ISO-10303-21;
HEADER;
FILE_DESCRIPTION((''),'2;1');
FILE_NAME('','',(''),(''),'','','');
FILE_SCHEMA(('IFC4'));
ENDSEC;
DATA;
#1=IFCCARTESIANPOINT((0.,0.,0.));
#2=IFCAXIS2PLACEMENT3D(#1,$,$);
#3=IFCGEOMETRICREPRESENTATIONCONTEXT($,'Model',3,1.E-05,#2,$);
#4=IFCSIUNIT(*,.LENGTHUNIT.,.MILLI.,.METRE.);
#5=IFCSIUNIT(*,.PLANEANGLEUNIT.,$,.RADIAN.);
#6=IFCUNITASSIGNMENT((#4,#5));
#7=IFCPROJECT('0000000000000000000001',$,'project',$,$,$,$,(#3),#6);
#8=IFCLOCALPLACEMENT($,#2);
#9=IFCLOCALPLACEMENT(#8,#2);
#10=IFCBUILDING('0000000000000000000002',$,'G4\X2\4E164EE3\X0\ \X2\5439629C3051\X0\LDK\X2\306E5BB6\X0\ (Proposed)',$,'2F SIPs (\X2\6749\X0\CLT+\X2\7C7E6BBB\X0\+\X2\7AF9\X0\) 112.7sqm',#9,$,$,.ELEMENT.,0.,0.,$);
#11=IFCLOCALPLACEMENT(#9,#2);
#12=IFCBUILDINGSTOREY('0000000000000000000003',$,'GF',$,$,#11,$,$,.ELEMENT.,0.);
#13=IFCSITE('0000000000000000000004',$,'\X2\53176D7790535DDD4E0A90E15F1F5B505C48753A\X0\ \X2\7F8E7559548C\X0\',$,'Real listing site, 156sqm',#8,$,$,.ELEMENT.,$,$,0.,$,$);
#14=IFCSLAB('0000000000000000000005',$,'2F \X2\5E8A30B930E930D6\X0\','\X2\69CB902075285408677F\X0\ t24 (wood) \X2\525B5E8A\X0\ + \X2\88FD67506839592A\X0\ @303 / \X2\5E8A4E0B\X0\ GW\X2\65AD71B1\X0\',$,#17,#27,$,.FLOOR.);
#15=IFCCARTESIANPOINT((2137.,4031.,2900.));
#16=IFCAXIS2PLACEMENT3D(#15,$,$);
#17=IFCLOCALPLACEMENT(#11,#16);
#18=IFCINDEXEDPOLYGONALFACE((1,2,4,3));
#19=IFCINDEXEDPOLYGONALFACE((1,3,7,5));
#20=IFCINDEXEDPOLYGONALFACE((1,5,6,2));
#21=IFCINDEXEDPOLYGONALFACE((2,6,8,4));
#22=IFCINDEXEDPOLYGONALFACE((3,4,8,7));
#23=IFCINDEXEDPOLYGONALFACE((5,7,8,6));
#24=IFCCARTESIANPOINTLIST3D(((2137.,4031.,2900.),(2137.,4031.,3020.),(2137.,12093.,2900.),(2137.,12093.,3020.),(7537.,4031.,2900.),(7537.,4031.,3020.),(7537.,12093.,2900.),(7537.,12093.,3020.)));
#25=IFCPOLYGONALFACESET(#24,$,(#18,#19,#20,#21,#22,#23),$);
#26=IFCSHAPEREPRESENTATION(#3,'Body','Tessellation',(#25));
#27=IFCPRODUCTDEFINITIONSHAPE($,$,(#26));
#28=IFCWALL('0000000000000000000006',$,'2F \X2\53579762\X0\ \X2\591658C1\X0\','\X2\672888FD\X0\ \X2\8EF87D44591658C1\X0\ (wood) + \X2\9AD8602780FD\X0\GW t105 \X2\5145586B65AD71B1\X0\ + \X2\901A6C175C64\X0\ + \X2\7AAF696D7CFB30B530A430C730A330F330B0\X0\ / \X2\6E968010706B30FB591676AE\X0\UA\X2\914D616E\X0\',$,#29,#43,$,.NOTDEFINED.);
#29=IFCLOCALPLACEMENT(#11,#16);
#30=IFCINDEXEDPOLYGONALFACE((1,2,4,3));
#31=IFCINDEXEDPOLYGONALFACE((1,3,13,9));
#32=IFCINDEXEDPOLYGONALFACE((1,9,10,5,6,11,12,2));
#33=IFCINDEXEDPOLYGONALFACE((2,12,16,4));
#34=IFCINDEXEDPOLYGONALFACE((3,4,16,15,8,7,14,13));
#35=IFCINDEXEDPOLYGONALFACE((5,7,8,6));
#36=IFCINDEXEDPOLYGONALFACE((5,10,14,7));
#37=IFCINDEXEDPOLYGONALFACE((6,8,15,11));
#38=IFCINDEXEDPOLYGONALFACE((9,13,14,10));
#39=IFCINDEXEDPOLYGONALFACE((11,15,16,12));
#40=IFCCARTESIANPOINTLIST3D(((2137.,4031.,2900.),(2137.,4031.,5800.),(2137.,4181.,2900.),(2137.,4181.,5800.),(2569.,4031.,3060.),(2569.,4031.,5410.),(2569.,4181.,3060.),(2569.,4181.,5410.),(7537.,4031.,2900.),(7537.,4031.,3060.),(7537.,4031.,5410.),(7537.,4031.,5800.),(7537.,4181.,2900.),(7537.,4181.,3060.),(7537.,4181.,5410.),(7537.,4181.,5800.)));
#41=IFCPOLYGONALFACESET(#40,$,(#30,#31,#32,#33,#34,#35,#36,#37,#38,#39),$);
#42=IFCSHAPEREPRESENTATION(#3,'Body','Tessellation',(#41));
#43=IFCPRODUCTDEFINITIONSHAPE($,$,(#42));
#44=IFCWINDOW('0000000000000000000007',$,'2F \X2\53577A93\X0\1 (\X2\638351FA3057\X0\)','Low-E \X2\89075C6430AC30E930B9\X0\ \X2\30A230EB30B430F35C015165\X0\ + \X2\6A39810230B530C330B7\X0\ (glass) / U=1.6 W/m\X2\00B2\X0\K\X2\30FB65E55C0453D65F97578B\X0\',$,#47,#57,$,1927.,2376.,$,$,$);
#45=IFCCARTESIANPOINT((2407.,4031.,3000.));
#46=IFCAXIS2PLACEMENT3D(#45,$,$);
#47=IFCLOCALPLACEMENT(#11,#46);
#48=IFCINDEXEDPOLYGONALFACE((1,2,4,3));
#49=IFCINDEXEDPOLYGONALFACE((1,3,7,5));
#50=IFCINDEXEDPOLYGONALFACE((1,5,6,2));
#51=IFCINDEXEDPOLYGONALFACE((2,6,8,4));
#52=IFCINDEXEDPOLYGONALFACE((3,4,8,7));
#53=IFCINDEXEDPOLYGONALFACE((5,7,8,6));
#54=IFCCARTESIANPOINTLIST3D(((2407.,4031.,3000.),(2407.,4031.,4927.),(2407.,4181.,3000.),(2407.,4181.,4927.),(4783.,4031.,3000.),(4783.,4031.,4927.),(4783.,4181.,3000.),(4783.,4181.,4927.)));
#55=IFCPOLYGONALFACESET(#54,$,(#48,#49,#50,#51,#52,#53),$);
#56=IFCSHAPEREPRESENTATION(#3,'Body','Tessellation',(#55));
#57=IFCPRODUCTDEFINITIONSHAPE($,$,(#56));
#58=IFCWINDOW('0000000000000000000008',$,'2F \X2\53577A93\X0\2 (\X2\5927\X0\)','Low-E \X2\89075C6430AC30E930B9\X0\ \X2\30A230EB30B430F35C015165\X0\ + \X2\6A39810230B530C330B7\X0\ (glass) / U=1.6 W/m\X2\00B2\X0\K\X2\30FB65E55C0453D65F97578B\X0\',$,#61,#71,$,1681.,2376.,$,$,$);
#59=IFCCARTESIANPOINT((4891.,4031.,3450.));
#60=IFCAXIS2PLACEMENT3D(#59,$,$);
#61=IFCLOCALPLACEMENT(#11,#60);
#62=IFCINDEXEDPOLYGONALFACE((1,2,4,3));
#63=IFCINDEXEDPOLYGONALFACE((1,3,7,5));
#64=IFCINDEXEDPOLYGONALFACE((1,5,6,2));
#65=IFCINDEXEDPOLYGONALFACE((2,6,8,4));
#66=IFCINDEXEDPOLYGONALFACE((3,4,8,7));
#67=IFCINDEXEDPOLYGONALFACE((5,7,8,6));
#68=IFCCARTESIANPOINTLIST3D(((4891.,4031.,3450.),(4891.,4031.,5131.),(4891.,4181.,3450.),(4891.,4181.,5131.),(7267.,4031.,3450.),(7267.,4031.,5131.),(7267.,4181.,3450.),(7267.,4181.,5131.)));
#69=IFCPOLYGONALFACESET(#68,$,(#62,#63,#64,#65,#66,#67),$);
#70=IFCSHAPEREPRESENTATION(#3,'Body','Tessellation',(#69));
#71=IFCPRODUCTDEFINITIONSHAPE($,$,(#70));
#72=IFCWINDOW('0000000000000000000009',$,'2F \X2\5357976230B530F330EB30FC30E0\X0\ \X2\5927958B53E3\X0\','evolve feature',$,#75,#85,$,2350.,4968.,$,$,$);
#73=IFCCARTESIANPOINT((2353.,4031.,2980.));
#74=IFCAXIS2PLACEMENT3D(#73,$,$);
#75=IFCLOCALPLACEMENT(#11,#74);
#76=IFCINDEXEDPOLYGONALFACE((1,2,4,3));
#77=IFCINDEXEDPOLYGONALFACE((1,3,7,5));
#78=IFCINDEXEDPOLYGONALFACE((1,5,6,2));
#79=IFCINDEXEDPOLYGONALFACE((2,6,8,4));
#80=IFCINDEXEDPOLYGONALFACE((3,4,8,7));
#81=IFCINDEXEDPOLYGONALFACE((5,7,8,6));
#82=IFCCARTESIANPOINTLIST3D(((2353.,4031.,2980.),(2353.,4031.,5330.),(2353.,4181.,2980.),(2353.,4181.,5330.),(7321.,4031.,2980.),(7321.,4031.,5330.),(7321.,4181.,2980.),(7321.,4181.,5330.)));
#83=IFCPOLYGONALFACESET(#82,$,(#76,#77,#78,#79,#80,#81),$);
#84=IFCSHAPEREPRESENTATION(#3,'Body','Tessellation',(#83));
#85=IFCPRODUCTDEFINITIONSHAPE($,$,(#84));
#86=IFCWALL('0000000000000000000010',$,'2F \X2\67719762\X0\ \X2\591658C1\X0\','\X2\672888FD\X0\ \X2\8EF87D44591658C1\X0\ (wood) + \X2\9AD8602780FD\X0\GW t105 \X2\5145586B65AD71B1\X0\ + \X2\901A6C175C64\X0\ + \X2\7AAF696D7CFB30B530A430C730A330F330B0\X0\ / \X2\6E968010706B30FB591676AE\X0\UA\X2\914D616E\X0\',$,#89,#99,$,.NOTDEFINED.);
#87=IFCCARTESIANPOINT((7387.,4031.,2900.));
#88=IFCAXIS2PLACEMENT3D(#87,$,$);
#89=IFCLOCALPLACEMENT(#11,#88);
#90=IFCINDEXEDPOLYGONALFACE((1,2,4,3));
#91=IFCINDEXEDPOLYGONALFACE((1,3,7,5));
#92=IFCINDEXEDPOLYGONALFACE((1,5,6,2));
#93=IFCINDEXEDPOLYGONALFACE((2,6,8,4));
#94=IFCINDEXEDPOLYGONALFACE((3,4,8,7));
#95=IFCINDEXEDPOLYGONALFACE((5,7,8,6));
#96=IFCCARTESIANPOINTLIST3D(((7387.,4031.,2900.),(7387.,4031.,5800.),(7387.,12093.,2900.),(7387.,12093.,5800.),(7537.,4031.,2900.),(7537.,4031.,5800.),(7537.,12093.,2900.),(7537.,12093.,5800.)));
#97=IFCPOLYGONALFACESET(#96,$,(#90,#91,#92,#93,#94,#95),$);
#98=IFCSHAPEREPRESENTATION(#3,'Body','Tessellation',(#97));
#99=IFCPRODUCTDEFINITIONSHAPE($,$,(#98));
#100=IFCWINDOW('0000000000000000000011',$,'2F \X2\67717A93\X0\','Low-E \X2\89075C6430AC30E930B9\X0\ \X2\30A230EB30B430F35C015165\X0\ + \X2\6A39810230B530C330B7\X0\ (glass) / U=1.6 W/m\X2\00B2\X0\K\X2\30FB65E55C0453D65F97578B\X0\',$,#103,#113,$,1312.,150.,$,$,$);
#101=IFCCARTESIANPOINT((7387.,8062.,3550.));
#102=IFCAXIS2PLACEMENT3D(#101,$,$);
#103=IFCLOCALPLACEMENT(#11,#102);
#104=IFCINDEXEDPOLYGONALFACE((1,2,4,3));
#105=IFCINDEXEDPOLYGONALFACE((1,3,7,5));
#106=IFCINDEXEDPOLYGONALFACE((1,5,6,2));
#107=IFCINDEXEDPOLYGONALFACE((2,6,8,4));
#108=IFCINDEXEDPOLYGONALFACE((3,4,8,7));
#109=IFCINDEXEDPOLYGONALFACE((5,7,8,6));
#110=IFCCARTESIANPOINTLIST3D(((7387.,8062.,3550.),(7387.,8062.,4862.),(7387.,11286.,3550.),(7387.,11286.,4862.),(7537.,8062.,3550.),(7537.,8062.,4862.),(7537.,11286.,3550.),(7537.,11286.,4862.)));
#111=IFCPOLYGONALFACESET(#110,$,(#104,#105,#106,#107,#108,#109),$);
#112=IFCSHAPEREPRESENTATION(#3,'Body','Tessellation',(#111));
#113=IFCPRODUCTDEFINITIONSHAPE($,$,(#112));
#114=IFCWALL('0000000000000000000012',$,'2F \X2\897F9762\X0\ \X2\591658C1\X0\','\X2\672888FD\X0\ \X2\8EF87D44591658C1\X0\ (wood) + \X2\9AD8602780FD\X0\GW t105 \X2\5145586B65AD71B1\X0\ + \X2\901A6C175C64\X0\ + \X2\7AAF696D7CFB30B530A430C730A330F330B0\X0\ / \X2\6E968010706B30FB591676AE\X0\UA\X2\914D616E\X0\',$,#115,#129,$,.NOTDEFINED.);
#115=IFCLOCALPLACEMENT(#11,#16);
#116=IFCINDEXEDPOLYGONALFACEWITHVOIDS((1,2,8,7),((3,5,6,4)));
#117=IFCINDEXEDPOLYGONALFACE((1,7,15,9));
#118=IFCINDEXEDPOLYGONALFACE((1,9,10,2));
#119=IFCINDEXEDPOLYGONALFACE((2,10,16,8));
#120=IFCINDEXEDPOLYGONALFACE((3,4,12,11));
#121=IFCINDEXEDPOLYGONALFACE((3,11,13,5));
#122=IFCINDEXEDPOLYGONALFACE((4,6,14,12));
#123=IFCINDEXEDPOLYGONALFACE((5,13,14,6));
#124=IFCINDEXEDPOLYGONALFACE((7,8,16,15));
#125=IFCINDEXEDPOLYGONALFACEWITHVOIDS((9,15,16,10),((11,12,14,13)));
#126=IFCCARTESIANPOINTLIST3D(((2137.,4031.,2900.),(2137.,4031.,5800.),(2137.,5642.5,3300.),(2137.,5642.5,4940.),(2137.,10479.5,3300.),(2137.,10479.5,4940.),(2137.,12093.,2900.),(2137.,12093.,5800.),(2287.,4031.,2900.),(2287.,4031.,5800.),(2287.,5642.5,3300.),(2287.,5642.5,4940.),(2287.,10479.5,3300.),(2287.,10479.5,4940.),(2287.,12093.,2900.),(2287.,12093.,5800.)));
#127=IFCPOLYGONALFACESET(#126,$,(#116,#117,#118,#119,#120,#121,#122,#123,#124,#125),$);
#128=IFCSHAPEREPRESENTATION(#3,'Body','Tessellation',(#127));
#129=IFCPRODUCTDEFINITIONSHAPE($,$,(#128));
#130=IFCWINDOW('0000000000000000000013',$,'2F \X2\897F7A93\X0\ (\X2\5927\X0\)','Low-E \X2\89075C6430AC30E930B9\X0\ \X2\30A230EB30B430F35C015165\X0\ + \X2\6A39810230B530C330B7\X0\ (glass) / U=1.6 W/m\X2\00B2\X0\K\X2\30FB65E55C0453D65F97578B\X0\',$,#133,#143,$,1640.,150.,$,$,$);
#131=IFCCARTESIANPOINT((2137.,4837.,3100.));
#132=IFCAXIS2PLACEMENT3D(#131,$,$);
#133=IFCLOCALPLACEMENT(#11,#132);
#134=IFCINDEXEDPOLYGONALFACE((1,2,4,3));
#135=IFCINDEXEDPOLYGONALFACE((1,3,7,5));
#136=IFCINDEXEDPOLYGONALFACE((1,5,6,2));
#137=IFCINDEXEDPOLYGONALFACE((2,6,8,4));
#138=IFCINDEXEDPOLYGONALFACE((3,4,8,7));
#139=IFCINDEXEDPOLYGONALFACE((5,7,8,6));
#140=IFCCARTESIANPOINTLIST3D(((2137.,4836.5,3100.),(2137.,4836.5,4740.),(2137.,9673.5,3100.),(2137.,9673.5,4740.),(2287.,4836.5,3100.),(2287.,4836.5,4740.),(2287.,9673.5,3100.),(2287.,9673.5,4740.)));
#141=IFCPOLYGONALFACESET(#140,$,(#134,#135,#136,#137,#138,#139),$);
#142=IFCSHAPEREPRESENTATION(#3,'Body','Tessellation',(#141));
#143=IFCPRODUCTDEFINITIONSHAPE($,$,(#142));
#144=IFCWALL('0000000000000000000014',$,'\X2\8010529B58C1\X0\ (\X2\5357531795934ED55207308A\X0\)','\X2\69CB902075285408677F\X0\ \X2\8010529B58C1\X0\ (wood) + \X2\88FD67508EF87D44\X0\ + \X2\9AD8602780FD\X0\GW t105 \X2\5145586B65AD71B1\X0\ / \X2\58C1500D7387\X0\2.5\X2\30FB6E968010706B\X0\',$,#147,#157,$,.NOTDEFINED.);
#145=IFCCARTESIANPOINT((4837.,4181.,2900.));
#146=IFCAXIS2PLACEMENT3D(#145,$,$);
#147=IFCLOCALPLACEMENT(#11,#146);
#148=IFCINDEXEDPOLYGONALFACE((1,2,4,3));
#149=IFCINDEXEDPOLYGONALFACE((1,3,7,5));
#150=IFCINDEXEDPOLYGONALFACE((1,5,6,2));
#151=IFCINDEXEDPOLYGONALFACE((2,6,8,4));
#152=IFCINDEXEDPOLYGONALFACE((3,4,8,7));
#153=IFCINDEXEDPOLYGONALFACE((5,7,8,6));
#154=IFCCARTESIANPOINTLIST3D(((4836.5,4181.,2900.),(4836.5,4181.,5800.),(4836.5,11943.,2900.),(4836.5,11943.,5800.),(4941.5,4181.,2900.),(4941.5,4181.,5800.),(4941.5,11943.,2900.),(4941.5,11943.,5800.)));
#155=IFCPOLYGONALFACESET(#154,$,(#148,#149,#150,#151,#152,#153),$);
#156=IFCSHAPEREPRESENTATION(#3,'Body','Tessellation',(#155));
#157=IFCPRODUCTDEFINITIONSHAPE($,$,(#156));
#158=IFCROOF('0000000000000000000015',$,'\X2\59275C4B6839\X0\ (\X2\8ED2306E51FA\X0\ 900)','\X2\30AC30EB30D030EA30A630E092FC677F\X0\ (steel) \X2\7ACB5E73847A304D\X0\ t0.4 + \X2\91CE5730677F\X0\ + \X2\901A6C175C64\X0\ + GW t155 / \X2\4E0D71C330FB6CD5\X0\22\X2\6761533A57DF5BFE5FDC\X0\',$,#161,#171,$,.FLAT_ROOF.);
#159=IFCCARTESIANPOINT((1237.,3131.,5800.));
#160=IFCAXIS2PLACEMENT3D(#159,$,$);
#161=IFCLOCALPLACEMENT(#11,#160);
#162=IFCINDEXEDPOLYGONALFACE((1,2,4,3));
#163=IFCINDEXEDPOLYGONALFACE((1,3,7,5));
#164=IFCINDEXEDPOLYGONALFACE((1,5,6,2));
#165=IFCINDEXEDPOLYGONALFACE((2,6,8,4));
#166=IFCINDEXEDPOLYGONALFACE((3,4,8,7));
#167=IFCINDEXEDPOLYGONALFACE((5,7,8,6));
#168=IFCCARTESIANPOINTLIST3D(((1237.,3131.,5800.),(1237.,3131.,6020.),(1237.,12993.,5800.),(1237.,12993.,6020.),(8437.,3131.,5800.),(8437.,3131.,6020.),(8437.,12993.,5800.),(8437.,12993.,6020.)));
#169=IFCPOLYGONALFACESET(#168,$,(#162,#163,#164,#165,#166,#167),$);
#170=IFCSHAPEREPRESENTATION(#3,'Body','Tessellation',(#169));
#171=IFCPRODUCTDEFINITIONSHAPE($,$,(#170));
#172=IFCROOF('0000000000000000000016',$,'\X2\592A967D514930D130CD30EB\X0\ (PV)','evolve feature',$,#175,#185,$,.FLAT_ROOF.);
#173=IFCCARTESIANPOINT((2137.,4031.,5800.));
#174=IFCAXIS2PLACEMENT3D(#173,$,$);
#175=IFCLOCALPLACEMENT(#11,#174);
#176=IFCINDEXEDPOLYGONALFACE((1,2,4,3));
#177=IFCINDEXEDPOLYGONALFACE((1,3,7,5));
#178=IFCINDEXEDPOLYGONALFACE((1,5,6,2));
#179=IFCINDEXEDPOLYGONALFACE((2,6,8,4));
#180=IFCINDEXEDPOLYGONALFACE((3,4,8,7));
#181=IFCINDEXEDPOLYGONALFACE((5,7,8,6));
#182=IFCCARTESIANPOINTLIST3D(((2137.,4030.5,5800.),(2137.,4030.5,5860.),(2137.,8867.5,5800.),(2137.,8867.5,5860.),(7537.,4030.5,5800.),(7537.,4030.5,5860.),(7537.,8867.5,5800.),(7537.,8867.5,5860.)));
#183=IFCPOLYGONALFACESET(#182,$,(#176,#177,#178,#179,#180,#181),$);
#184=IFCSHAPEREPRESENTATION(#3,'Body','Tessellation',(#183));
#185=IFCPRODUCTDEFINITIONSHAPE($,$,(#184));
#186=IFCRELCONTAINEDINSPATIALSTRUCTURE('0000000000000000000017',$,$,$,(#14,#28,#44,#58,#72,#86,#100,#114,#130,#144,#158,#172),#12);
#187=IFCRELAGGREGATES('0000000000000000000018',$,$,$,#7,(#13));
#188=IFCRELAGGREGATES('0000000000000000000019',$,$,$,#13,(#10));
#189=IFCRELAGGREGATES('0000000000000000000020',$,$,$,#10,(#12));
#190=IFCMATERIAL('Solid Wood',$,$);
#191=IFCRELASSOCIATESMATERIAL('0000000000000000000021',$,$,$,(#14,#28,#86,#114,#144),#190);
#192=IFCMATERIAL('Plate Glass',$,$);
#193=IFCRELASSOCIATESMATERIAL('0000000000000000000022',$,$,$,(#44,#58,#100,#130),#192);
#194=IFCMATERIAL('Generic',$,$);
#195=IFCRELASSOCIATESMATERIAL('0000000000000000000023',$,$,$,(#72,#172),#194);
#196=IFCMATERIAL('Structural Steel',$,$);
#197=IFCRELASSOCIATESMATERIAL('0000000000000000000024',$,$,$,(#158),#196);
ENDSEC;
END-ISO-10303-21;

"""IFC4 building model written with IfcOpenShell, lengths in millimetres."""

from ifc_helpers import new_model, si_unit, frame, frame_2d, origin, place, context, project, spatial, rectangle, extrude, material, element, fill, save


model = new_model("IFC4")

# Units and contexts
model_context = context("Model", 3, precision=1e-05, world=origin())
ifc_project = project(units=[si_unit("LENGTHUNIT", "METRE", prefix="MILLI"), si_unit("PLANEANGLEUNIT", "RADIAN")], contexts=[model_context])

# Site, building, storey
site_placement = place(None, origin())
site = spatial("IfcSite", under=ifc_project, at=site_placement, Name="北海道川上郡弟子屈町 美留和", ObjectType="Real listing site, 156sqm", CompositionType="ELEMENT", RefElevation=0.0)
building_placement = place(site_placement, origin())
building = spatial("IfcBuilding", under=site, at=building_placement, Name="G4世代 吹抜けLDKの家 (Proposed)", ObjectType="2F SIPs (杉CLT+籾殻+竹) 112.7sqm", CompositionType="ELEMENT", ElevationOfRefHeight=0.0, ElevationOfTerrain=0.0)
storey_placement = place(building_placement, origin())
storey = spatial("IfcBuildingStorey", under=building, at=storey_placement, Name="GF", CompositionType="ELEMENT", Elevation=0.0)

# Slab
ifc_material_1 = material(Name="Solid Wood")
slab_placement = place(storey_placement, frame((2137.0, 4031.0, 2900.0)))
element("IfcSlab", 1, at=slab_placement, inside=storey, material=ifc_material_1, Name="2F 床スラブ", Description="構造用合板 t24 (wood) 剛床 + 製材根太 @303 / 床下 GW断熱", PredefinedType="FLOOR", context=model_context, shape_type="SweptSolid", body=[
    extrude(rectangle(XDim=5400.0, YDim=8062.0, at=frame_2d((2700.0, 4031.0))), frame((2137.0, 4031.0, 2900.0)), (0.0, 0.0, 1.0), 120.0),
])

# Wall, openings, windows
wall_1_placement = place(storey_placement, frame((2137.0, 4031.0, 2900.0)))
wall_1 = element("IfcWall", 2, at=wall_1_placement, inside=storey, material=ifc_material_1, Name="2F 南面 外壁", Description="木製 軸組外壁 (wood) + 高性能GW t105 充填断熱 + 通気層 + 窯業系サイディング / 準耐火・外皮UA配慮", PredefinedType="NOTDEFINED", context=model_context, shape_type="SweptSolid", body=[
    extrude(rectangle(XDim=5400.0, YDim=150.0, at=frame_2d((2700.0, 75.0))), frame((2137.0, 4031.0, 2900.0)), (0.0, 0.0, 1.0), 2900.0),
])
opening_1_placement = place(storey_placement, frame((2407.0, 4031.0, 3000.0)))
opening_1 = element("IfcOpeningElement", 3, at=opening_1_placement, cuts=wall_1, PredefinedType="NOTDEFINED", context=model_context, shape_type="SweptSolid", body=[
    extrude(rectangle(XDim=2376.0, YDim=150.0, at=frame_2d((1188.0, 75.0))), frame((2407.0, 4031.0, 3000.0)), (0.0, 0.0, 1.0), 1927.0),
])
opening_2_placement = place(storey_placement, frame((4891.0, 4031.0, 3450.0)))
opening_2 = element("IfcOpeningElement", 4, at=opening_2_placement, cuts=wall_1, PredefinedType="NOTDEFINED", context=model_context, shape_type="SweptSolid", body=[
    extrude(rectangle(XDim=2376.0, YDim=150.0, at=frame_2d((1188.0, 75.0))), frame((4891.0, 4031.0, 3450.0)), (0.0, 0.0, 1.0), 1681.0),
])
opening_3_placement = place(storey_placement, frame((2353.0, 4031.0, 2980.0)))
opening_3 = element("IfcOpeningElement", 5, at=opening_3_placement, cuts=wall_1, PredefinedType="NOTDEFINED", context=model_context, shape_type="SweptSolid", body=[
    extrude(rectangle(XDim=4968.0, YDim=150.0, at=frame_2d((2484.0, 75.0))), frame((2353.0, 4031.0, 2980.0)), (0.0, 0.0, 1.0), 2350.0),
])
ifc_material_2 = material(Name="Plate Glass")
window_1_placement = place(storey_placement, frame((2407.0, 4031.0, 3000.0)))
window_1 = element("IfcWindow", 6, at=window_1_placement, inside=storey, material=ifc_material_2, Name="2F 南窓1 (掃出し)", Description="Low-E 複層ガラス アルゴン封入 + 樹脂サッシ (glass) / U=1.6 W/m²K・日射取得型", OverallHeight=1927.0, OverallWidth=2376.0, context=model_context, shape_type="SweptSolid", body=[
    extrude(rectangle(XDim=2376.0, YDim=150.0, at=frame_2d((1188.0, 75.0))), frame((2407.0, 4031.0, 3000.0)), (0.0, 0.0, 1.0), 1927.0),
])
fill(opening_1, window_1)
window_2_placement = place(storey_placement, frame((4891.0, 4031.0, 3450.0)))
window_2 = element("IfcWindow", 7, at=window_2_placement, inside=storey, material=ifc_material_2, Name="2F 南窓2 (大)", Description="Low-E 複層ガラス アルゴン封入 + 樹脂サッシ (glass) / U=1.6 W/m²K・日射取得型", OverallHeight=1681.0, OverallWidth=2376.0, context=model_context, shape_type="SweptSolid", body=[
    extrude(rectangle(XDim=2376.0, YDim=150.0, at=frame_2d((1188.0, 75.0))), frame((4891.0, 4031.0, 3450.0)), (0.0, 0.0, 1.0), 1681.0),
])
fill(opening_2, window_2)
ifc_material_3 = material(Name="Generic")
window_3_placement = place(storey_placement, frame((2353.0, 4031.0, 2980.0)))
window_3 = element("IfcWindow", 8, at=window_3_placement, inside=storey, material=ifc_material_3, Name="2F 南面サンルーム 大開口", Description="evolve feature", OverallHeight=2350.0, OverallWidth=4968.0, context=model_context, shape_type="SweptSolid", body=[
    extrude(rectangle(XDim=4968.0, YDim=150.0, at=frame_2d((2484.0, 75.0))), frame((2353.0, 4031.0, 2980.0)), (0.0, 0.0, 1.0), 2350.0),
])
fill(opening_3, window_3)

# Walls, openings, windows
wall_2_placement = place(storey_placement, frame((7387.0, 4031.0, 2900.0)))
wall_2 = element("IfcWall", 9, at=wall_2_placement, inside=storey, material=ifc_material_1, Name="2F 東面 外壁", Description="木製 軸組外壁 (wood) + 高性能GW t105 充填断熱 + 通気層 + 窯業系サイディング / 準耐火・外皮UA配慮", PredefinedType="NOTDEFINED", context=model_context, shape_type="SweptSolid", body=[
    extrude(rectangle(XDim=150.0, YDim=8062.0, at=frame_2d((75.0, 4031.0))), frame((7387.0, 4031.0, 2900.0)), (0.0, 0.0, 1.0), 2900.0),
])
opening_4_placement = place(storey_placement, frame((7387.0, 8062.0, 3550.0)))
opening_4 = element("IfcOpeningElement", 10, at=opening_4_placement, cuts=wall_2, PredefinedType="NOTDEFINED", context=model_context, shape_type="SweptSolid", body=[
    extrude(rectangle(XDim=150.0, YDim=3224.0, at=frame_2d((75.0, 1612.0))), frame((7387.0, 8062.0, 3550.0)), (0.0, 0.0, 1.0), 1312.0),
])
window_4_placement = place(storey_placement, frame((7387.0, 8062.0, 3550.0)))
window_4 = element("IfcWindow", 11, at=window_4_placement, inside=storey, material=ifc_material_2, Name="2F 東窓", Description="Low-E 複層ガラス アルゴン封入 + 樹脂サッシ (glass) / U=1.6 W/m²K・日射取得型", OverallHeight=1312.0, OverallWidth=150.0, context=model_context, shape_type="SweptSolid", body=[
    extrude(rectangle(XDim=150.0, YDim=3224.0, at=frame_2d((75.0, 1612.0))), frame((7387.0, 8062.0, 3550.0)), (0.0, 0.0, 1.0), 1312.0),
])
fill(opening_4, window_4)
wall_3_placement = place(storey_placement, frame((2137.0, 4031.0, 2900.0)))
wall_3 = element("IfcWall", 12, at=wall_3_placement, inside=storey, material=ifc_material_1, Name="2F 西面 外壁", Description="木製 軸組外壁 (wood) + 高性能GW t105 充填断熱 + 通気層 + 窯業系サイディング / 準耐火・外皮UA配慮", PredefinedType="NOTDEFINED", context=model_context, shape_type="SweptSolid", body=[
    extrude(rectangle(XDim=150.0, YDim=8062.0, at=frame_2d((75.0, 4031.0))), frame((2137.0, 4031.0, 2900.0)), (0.0, 0.0, 1.0), 2900.0),
])
opening_5_placement = place(storey_placement, frame((2137.0, 4837.0, 3100.0)))
opening_5 = element("IfcOpeningElement", 13, at=opening_5_placement, cuts=wall_3, PredefinedType="NOTDEFINED", context=model_context, shape_type="SweptSolid", body=[
    extrude(rectangle(XDim=150.0, YDim=4837.0, at=frame_2d((75.0, 2418.0))), frame((2137.0, 4837.0, 3100.0)), (0.0, 0.0, 1.0), 1640.0),
])
window_5_placement = place(storey_placement, frame((2137.0, 4837.0, 3100.0)))
window_5 = element("IfcWindow", 14, at=window_5_placement, inside=storey, material=ifc_material_2, Name="2F 西窓 (大)", Description="Low-E 複層ガラス アルゴン封入 + 樹脂サッシ (glass) / U=1.6 W/m²K・日射取得型", OverallHeight=1640.0, OverallWidth=150.0, context=model_context, shape_type="SweptSolid", body=[
    extrude(rectangle(XDim=150.0, YDim=4837.0, at=frame_2d((75.0, 2418.0))), frame((2137.0, 4837.0, 3100.0)), (0.0, 0.0, 1.0), 1640.0),
])
fill(opening_5, window_5)

# Wall
wall_4_placement = place(storey_placement, frame((4837.0, 4181.0, 2900.0)))
element("IfcWall", 15, at=wall_4_placement, inside=storey, material=ifc_material_1, Name="耐力壁 (南北間仕切り)", Description="構造用合板 耐力壁 (wood) + 製材軸組 + 高性能GW t105 充填断熱 / 壁倍率2.5・準耐火", PredefinedType="NOTDEFINED", context=model_context, shape_type="SweptSolid", body=[
    extrude(rectangle(XDim=105.0, YDim=7762.0, at=frame_2d((52.0, 3881.0))), frame((4837.0, 4181.0, 2900.0)), (0.0, 0.0, 1.0), 2900.0),
])

# Roofs
ifc_material_4 = material(Name="Structural Steel")
roof_1_placement = place(storey_placement, frame((1237.0, 3131.0, 5800.0)))
element("IfcRoof", 16, at=roof_1_placement, inside=storey, material=ifc_material_4, Name="大屋根 (軒の出 900)", Description="ガルバリウム鋼板 (steel) 立平葺き t0.4 + 野地板 + 通気層 + GW t155 / 不燃・法22条区域対応", PredefinedType="FLAT_ROOF", context=model_context, shape_type="SweptSolid", body=[
    extrude(rectangle(XDim=7200.0, YDim=9862.0, at=frame_2d((3600.0, 4931.0))), frame((1237.0, 3131.0, 5800.0)), (0.0, 0.0, 1.0), 220.0),
])
roof_2_placement = place(storey_placement, frame((2137.0, 4031.0, 5800.0)))
element("IfcRoof", 17, at=roof_2_placement, inside=storey, material=ifc_material_3, Name="太陽光パネル (PV)", Description="evolve feature", PredefinedType="FLAT_ROOF", context=model_context, shape_type="SweptSolid", body=[
    extrude(rectangle(XDim=5400.0, YDim=4837.0, at=frame_2d((2700.0, 2418.0))), frame((2137.0, 4031.0, 5800.0)), (0.0, 0.0, 1.0), 60.0),
])

save(model, "model.ifc")
